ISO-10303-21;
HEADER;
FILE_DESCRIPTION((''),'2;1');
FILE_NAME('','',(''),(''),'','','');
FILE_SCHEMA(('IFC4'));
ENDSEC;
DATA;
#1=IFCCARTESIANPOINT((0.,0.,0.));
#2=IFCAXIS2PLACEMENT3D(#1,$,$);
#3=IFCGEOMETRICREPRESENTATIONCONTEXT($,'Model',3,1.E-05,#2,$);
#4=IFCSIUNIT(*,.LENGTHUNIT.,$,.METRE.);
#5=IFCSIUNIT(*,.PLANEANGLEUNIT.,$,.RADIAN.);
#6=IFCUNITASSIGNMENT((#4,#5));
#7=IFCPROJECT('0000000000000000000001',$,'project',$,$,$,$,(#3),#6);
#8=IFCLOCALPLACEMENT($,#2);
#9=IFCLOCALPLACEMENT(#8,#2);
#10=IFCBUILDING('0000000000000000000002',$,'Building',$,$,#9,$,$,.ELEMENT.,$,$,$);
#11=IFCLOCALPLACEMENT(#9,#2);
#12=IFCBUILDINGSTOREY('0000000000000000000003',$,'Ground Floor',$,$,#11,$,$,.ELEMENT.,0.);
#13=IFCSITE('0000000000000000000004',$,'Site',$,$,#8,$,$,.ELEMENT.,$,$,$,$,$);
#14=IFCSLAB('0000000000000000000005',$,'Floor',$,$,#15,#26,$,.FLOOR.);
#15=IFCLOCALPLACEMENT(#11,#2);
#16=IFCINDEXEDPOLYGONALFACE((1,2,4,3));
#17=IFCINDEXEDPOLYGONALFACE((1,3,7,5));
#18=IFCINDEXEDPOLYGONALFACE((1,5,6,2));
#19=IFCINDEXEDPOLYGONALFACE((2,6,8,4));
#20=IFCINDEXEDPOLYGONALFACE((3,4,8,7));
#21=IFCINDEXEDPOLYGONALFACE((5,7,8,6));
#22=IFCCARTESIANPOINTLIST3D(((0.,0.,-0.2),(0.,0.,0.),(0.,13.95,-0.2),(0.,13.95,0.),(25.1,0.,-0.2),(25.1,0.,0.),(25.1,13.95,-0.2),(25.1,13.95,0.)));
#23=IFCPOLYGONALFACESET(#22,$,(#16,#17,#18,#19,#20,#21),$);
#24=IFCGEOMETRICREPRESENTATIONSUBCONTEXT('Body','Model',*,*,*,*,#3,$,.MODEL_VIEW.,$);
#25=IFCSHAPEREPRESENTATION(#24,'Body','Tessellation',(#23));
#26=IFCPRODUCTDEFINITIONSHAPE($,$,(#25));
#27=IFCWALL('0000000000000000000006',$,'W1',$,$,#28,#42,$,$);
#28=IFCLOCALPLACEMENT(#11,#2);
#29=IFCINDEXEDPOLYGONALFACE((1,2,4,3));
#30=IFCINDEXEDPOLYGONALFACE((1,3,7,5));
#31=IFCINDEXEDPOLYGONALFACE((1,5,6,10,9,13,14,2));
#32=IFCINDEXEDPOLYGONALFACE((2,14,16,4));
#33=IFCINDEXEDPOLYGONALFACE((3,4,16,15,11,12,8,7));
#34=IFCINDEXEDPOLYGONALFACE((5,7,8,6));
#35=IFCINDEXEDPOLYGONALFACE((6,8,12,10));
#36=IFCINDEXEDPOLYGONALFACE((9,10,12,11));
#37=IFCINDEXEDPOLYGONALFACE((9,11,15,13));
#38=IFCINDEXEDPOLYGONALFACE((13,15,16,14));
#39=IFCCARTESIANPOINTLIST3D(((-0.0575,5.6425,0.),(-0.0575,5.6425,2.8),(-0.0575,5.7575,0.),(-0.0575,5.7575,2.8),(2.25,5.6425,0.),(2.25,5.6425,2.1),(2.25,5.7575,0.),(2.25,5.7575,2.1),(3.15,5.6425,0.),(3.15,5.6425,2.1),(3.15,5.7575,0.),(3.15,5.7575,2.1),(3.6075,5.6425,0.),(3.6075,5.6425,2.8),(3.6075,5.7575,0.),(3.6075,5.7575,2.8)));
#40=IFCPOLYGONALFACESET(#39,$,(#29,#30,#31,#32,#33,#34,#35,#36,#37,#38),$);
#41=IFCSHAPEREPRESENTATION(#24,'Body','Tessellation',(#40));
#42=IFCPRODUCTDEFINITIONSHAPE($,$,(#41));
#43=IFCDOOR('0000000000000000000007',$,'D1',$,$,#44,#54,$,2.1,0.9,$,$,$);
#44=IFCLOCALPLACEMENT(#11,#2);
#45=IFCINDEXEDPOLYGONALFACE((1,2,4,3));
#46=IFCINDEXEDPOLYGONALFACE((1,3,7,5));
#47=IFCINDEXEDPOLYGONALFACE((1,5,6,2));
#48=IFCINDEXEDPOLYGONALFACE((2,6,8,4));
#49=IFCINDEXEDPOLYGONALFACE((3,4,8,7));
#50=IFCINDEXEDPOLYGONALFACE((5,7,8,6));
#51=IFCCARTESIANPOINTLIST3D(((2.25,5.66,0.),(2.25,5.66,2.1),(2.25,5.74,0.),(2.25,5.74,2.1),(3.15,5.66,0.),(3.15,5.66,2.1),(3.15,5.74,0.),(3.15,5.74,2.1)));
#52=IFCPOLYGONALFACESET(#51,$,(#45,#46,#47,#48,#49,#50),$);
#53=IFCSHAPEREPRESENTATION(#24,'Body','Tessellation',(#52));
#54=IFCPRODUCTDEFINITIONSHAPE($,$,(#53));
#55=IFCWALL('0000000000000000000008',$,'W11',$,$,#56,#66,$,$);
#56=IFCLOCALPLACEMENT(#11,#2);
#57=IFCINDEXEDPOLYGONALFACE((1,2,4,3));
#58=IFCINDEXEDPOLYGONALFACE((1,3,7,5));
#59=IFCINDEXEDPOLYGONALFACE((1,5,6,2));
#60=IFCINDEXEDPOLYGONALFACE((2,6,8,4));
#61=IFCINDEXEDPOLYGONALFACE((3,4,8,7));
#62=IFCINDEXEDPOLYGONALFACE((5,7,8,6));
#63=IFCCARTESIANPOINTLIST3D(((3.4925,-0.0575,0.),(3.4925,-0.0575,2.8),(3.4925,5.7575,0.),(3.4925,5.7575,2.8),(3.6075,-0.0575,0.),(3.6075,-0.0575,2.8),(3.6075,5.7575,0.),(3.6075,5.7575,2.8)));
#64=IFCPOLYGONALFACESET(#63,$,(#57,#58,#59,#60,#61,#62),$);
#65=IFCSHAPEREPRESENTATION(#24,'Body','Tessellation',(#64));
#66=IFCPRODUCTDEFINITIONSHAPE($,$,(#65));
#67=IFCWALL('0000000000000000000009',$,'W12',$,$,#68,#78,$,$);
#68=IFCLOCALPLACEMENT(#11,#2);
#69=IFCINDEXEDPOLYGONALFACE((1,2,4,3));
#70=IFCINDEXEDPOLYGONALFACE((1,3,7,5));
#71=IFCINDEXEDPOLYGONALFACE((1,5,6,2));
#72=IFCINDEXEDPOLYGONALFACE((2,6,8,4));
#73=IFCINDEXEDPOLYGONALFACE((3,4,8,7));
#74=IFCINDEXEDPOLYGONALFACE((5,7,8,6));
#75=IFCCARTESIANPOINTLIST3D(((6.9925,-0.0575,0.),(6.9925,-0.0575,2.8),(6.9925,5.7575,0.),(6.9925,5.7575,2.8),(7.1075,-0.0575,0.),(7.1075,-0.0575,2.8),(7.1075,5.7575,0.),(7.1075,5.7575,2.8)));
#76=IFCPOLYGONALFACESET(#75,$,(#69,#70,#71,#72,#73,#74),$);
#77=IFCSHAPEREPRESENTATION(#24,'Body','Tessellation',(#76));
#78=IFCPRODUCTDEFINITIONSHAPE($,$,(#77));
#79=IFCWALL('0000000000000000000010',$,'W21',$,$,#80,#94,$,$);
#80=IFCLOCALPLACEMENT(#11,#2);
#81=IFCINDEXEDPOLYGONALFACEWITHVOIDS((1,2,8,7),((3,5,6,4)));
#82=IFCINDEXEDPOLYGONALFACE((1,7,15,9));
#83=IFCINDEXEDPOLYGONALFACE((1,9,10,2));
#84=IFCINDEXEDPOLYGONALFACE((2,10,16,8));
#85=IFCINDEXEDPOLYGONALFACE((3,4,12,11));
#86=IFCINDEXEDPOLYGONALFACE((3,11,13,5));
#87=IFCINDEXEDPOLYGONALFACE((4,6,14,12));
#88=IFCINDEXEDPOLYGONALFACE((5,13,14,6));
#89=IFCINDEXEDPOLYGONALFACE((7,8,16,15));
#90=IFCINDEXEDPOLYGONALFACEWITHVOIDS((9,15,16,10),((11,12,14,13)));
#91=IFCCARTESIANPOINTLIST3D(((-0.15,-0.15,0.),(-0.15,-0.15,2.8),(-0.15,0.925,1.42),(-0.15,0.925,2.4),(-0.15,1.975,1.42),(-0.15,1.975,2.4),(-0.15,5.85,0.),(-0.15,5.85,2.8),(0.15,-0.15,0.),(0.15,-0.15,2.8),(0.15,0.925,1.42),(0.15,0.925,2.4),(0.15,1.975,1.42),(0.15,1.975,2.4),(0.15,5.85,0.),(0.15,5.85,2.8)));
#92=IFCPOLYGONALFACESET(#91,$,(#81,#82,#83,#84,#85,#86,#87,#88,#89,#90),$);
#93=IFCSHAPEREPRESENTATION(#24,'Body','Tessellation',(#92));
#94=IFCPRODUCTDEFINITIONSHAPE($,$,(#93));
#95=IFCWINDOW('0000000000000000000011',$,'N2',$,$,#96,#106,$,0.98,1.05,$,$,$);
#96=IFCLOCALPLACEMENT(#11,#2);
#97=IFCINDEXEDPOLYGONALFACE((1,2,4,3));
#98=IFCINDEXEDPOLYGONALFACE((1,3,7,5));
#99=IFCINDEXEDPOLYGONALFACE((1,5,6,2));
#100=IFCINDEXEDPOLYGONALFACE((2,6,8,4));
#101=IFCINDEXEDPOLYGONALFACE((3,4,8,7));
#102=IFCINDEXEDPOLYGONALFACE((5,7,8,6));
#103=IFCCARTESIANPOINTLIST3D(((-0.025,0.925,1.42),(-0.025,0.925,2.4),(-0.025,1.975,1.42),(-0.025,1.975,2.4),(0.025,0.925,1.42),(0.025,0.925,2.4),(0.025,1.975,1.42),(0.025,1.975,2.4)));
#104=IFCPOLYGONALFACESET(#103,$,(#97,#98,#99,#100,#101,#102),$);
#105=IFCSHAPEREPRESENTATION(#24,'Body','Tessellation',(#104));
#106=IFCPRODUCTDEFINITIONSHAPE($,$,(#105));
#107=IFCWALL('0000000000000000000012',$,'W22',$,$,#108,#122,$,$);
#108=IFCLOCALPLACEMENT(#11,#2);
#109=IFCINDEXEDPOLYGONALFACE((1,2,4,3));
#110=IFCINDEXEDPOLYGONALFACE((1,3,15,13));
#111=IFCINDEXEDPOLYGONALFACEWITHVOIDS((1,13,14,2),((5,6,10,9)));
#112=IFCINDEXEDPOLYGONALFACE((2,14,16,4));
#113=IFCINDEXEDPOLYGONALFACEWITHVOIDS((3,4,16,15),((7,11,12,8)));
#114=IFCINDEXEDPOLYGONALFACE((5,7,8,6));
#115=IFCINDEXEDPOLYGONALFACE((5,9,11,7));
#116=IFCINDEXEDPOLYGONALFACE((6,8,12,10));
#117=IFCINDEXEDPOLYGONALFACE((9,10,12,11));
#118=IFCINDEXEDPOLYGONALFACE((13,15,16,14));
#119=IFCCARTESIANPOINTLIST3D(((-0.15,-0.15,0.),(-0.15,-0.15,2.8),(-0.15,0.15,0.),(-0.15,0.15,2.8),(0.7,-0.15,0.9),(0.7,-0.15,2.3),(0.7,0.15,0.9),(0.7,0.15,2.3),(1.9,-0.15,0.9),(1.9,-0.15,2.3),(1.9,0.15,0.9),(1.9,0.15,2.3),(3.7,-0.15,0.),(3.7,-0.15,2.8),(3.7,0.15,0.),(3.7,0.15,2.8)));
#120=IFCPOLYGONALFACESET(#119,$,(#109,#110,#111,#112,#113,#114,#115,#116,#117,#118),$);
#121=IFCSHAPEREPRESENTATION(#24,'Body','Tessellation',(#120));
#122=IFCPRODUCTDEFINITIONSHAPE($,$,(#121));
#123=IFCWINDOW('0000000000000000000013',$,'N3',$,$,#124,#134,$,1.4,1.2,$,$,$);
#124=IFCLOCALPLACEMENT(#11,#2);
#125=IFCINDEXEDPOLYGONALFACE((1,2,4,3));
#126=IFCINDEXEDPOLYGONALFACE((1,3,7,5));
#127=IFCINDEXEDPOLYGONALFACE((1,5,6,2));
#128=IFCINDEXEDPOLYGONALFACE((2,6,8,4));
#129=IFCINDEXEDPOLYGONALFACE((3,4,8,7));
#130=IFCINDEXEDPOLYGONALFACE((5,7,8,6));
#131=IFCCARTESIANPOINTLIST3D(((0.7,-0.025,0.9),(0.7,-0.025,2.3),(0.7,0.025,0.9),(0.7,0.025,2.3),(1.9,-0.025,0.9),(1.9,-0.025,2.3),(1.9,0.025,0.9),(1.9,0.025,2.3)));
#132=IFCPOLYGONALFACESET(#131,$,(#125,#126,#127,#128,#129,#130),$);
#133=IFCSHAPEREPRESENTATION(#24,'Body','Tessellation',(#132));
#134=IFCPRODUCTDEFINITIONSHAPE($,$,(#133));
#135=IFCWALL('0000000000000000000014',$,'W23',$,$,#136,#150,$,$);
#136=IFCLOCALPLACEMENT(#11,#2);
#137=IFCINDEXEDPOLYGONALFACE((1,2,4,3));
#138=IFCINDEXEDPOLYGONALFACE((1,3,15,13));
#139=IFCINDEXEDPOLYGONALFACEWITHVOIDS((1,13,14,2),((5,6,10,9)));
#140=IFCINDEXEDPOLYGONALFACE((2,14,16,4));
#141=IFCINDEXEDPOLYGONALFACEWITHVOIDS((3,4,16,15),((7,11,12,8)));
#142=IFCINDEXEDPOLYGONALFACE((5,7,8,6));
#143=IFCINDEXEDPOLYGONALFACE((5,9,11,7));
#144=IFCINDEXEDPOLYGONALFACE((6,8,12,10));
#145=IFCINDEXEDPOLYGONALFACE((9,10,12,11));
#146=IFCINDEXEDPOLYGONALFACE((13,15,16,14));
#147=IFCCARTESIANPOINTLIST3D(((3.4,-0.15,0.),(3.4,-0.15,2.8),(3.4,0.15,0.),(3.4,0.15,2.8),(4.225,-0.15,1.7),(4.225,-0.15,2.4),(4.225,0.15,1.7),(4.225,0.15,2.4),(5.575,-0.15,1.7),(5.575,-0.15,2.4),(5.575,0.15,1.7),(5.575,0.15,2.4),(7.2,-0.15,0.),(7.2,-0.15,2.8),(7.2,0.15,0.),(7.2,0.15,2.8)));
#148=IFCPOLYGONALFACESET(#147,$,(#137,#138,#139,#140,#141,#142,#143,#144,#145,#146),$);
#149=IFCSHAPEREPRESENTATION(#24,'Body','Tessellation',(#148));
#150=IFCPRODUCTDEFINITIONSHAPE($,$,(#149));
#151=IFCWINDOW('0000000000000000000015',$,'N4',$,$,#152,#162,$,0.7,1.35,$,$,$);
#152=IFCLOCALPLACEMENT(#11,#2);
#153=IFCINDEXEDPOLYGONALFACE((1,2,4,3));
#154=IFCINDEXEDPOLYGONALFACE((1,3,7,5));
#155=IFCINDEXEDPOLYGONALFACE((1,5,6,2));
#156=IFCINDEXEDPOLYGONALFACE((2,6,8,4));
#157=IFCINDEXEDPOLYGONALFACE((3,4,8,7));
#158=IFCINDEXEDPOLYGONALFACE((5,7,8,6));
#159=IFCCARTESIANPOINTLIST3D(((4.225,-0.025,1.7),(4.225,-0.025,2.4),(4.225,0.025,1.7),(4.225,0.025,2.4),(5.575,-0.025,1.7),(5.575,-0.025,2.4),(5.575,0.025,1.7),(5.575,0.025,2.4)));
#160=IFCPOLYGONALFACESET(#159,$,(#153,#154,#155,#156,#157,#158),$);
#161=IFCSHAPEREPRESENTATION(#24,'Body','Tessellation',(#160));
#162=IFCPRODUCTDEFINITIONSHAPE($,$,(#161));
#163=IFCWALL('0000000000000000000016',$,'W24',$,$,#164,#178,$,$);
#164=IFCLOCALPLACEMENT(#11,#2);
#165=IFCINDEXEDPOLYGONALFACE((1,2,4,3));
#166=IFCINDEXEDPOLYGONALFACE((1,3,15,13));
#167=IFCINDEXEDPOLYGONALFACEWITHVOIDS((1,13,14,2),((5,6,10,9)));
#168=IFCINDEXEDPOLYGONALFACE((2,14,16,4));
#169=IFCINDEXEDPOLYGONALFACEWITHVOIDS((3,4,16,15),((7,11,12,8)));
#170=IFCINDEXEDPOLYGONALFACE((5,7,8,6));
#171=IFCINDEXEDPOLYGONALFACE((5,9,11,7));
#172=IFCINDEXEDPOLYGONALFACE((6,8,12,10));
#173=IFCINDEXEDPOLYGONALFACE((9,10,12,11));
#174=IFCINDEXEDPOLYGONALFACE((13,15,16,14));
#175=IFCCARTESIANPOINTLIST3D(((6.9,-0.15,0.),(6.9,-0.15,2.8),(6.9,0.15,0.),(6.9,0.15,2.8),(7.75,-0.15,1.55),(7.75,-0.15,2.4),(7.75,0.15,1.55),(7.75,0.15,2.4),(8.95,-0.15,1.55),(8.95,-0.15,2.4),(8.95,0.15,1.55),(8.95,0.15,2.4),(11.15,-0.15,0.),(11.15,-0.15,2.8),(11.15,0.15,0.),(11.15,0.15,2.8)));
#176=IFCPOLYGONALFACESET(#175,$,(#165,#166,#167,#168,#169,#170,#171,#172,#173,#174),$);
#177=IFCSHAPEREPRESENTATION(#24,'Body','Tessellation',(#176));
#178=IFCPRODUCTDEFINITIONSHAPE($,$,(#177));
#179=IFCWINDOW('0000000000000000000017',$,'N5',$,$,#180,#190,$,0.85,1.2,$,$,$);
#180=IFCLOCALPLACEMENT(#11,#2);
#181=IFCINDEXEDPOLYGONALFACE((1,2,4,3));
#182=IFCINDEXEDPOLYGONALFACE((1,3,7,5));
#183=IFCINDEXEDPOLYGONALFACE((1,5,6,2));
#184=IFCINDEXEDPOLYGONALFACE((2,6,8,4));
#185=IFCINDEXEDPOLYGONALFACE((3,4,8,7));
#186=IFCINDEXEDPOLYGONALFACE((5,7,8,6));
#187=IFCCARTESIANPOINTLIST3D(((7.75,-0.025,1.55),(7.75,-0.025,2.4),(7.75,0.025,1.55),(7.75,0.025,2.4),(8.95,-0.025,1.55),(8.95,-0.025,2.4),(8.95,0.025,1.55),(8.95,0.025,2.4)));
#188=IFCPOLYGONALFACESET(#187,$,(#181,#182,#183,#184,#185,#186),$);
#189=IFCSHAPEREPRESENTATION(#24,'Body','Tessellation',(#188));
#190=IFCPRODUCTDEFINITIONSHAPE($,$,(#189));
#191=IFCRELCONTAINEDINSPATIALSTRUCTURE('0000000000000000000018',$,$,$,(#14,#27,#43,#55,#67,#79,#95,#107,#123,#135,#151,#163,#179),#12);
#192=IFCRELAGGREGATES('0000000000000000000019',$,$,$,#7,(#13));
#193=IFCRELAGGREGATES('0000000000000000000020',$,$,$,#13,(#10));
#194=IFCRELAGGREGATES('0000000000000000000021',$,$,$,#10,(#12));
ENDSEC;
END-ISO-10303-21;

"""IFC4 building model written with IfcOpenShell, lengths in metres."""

from ifc_helpers import new_model, si_unit, frame, frame_2d, origin, origin_2d, place, context, subcontext, project, spatial, polyline, rectangle, outline, extrude, element, fill, save


model = new_model("IFC4")

# Units and contexts
model_context = context("Model", 3, precision=1e-05, world=origin())
body_context = subcontext(model_context, "Body", "Model", "MODEL_VIEW")
ifc_project = project(units=[si_unit("LENGTHUNIT", "METRE"), si_unit("PLANEANGLEUNIT", "RADIAN")], contexts=[model_context])

# Site, building, storey
site_placement = place(None, origin())
site = spatial("IfcSite", under=ifc_project, at=site_placement, Name="Site", CompositionType="ELEMENT")
building_placement = place(site_placement, origin())
building = spatial("IfcBuilding", under=site, at=building_placement, Name="Building", CompositionType="ELEMENT")
storey_placement = place(building_placement, origin())
storey = spatial("IfcBuildingStorey", under=building, at=storey_placement, Name="Ground Floor", CompositionType="ELEMENT", Elevation=0.0)

# Slab
slab_placement = place(storey_placement, origin())
element("IfcSlab", 1, at=slab_placement, inside=storey, Name="Floor", PredefinedType="FLOOR", context=body_context, shape_type="SweptSolid", body=[
    extrude(outline(polyline([(0.0, 0.0), (25.1, 0.0), (25.1, 13.95), (0.0, 13.95), (0.0, 0.0)])), origin(), (0.0, 0.0, -1.0), 0.2),
])

# Wall, opening, door
wall_1_placement = place(storey_placement, frame((0.0, 5.7, 0.0), x_axis=(1.0, 0.0, 0.0)))
wall_1 = element("IfcWall", 2, at=wall_1_placement, inside=storey, Name="W1", context=body_context, shape_type="SweptSolid", body=[
    extrude(rectangle(XDim=3.665, YDim=0.115, at=frame_2d((1.775, 0.0))), origin(), (0.0, 0.0, 1.0), 2.8),
])
opening_1_placement = place(wall_1_placement, frame((2.7, 0.0, 0.0)))
opening_1 = element("IfcOpeningElement", 3, at=opening_1_placement, cuts=wall_1, context=body_context, shape_type="SweptSolid", body=[
    extrude(rectangle(XDim=0.9, YDim=0.215, at=origin_2d()), origin(), (0.0, 0.0, 1.0), 2.1),
])
door_placement = place(opening_1_placement, origin())
door = element("IfcDoor", 4, at=door_placement, inside=storey, Name="D1", OverallHeight=2.1, OverallWidth=0.9, context=body_context, shape_type="SweptSolid", body=[
    extrude(rectangle(XDim=0.9, YDim=0.08, at=origin_2d()), origin(), (0.0, 0.0, 1.0), 2.1),
])
fill(opening_1, door)

# Walls
for number, where, x_axis, name in (
    (5, (3.55, 0.0, 0.0), (0.0, 1.0, 0.0), "W11"),
    (6, (7.05, 0.0, 0.0), (0.0, 1.0, 0.0), "W12"),
):
    element("IfcWall", number, at=place(storey_placement, frame(where, x_axis=x_axis)), inside=storey, Name=name, context=body_context, shape_type="SweptSolid", body=[
        extrude(rectangle(XDim=5.815, YDim=0.115, at=frame_2d((2.85, 0.0))), origin(), (0.0, 0.0, 1.0), 2.8),
    ])

# Walls, openings, windows
wall_2_placement = place(storey_placement, frame((0.0, 0.0, 0.0), x_axis=(0.0, 1.0, 0.0)))
wall_2 = element("IfcWall", 7, at=wall_2_placement, inside=storey, Name="W21", context=body_context, shape_type="SweptSolid", body=[
    extrude(rectangle(XDim=6.0, YDim=0.3, at=frame_2d((2.85, 0.0))), origin(), (0.0, 0.0, 1.0), 2.8),
])
opening_2_placement = place(wall_2_placement, frame((1.45, 0.0, 1.42)))
opening_2 = element("IfcOpeningElement", 8, at=opening_2_placement, cuts=wall_2, context=body_context, shape_type="SweptSolid", body=[
    extrude(rectangle(XDim=1.05, YDim=0.4, at=origin_2d()), origin(), (0.0, 0.0, 1.0), 0.98),
])
window_1_placement = place(opening_2_placement, origin())
window_1 = element("IfcWindow", 9, at=window_1_placement, inside=storey, Name="N2", OverallHeight=0.98, OverallWidth=1.05, context=body_context, shape_type="SweptSolid", body=[
    extrude(rectangle(XDim=1.05, YDim=0.05, at=origin_2d()), origin(), (0.0, 0.0, 1.0), 0.98),
])
fill(opening_2, window_1)
wall_3_placement = place(storey_placement, frame((0.0, 0.0, 0.0), x_axis=(1.0, 0.0, 0.0)))
wall_3 = element("IfcWall", 10, at=wall_3_placement, inside=storey, Name="W22", context=body_context, shape_type="SweptSolid", body=[
    extrude(rectangle(XDim=3.85, YDim=0.3, at=frame_2d((1.775, 0.0))), origin(), (0.0, 0.0, 1.0), 2.8),
])
opening_3_placement = place(wall_3_placement, frame((1.3, 0.0, 0.9)))
opening_3 = element("IfcOpeningElement", 11, at=opening_3_placement, cuts=wall_3, context=body_context, shape_type="SweptSolid", body=[
    extrude(rectangle(XDim=1.2, YDim=0.4, at=origin_2d()), origin(), (0.0, 0.0, 1.0), 1.4),
])
window_2_placement = place(opening_3_placement, origin())
window_2 = element("IfcWindow", 12, at=window_2_placement, inside=storey, Name="N3", OverallHeight=1.4, OverallWidth=1.2, context=body_context, shape_type="SweptSolid", body=[
    extrude(rectangle(XDim=1.2, YDim=0.05, at=origin_2d()), origin(), (0.0, 0.0, 1.0), 1.4),
])
fill(opening_3, window_2)
wall_4_placement = place(storey_placement, frame((3.55, 0.0, 0.0), x_axis=(1.0, 0.0, 0.0)))
wall_4 = element("IfcWall", 13, at=wall_4_placement, inside=storey, Name="W23", context=body_context, shape_type="SweptSolid", body=[
    extrude(rectangle(XDim=3.8, YDim=0.3, at=frame_2d((1.75, 0.0))), origin(), (0.0, 0.0, 1.0), 2.8),
])
opening_4_placement = place(wall_4_placement, frame((1.35, 0.0, 1.7)))
opening_4 = element("IfcOpeningElement", 14, at=opening_4_placement, cuts=wall_4, context=body_context, shape_type="SweptSolid", body=[
    extrude(rectangle(XDim=1.35, YDim=0.4, at=origin_2d()), origin(), (0.0, 0.0, 1.0), 0.7),
])
window_3_placement = place(opening_4_placement, origin())
window_3 = element("IfcWindow", 15, at=window_3_placement, inside=storey, Name="N4", OverallHeight=0.7, OverallWidth=1.35, context=body_context, shape_type="SweptSolid", body=[
    extrude(rectangle(XDim=1.35, YDim=0.05, at=origin_2d()), origin(), (0.0, 0.0, 1.0), 0.7),
])
fill(opening_4, window_3)
wall_5_placement = place(storey_placement, frame((7.05, 0.0, 0.0), x_axis=(1.0, 0.0, 0.0)))
wall_5 = element("IfcWall", 16, at=wall_5_placement, inside=storey, Name="W24", context=body_context, shape_type="SweptSolid", body=[
    extrude(rectangle(XDim=4.25, YDim=0.3, at=frame_2d((1.975, 0.0))), origin(), (0.0, 0.0, 1.0), 2.8),
])
opening_5_placement = place(wall_5_placement, frame((1.3, 0.0, 1.55)))
opening_5 = element("IfcOpeningElement", 17, at=opening_5_placement, cuts=wall_5, context=body_context, shape_type="SweptSolid", body=[
    extrude(rectangle(XDim=1.2, YDim=0.4, at=origin_2d()), origin(), (0.0, 0.0, 1.0), 0.85),
])
window_4_placement = place(opening_5_placement, origin())
window_4 = element("IfcWindow", 18, at=window_4_placement, inside=storey, Name="N5", OverallHeight=0.85, OverallWidth=1.2, context=body_context, shape_type="SweptSolid", body=[
    extrude(rectangle(XDim=1.2, YDim=0.05, at=origin_2d()), origin(), (0.0, 0.0, 1.0), 0.85),
])
fill(opening_5, window_4)

save(model, "model.ifc")
